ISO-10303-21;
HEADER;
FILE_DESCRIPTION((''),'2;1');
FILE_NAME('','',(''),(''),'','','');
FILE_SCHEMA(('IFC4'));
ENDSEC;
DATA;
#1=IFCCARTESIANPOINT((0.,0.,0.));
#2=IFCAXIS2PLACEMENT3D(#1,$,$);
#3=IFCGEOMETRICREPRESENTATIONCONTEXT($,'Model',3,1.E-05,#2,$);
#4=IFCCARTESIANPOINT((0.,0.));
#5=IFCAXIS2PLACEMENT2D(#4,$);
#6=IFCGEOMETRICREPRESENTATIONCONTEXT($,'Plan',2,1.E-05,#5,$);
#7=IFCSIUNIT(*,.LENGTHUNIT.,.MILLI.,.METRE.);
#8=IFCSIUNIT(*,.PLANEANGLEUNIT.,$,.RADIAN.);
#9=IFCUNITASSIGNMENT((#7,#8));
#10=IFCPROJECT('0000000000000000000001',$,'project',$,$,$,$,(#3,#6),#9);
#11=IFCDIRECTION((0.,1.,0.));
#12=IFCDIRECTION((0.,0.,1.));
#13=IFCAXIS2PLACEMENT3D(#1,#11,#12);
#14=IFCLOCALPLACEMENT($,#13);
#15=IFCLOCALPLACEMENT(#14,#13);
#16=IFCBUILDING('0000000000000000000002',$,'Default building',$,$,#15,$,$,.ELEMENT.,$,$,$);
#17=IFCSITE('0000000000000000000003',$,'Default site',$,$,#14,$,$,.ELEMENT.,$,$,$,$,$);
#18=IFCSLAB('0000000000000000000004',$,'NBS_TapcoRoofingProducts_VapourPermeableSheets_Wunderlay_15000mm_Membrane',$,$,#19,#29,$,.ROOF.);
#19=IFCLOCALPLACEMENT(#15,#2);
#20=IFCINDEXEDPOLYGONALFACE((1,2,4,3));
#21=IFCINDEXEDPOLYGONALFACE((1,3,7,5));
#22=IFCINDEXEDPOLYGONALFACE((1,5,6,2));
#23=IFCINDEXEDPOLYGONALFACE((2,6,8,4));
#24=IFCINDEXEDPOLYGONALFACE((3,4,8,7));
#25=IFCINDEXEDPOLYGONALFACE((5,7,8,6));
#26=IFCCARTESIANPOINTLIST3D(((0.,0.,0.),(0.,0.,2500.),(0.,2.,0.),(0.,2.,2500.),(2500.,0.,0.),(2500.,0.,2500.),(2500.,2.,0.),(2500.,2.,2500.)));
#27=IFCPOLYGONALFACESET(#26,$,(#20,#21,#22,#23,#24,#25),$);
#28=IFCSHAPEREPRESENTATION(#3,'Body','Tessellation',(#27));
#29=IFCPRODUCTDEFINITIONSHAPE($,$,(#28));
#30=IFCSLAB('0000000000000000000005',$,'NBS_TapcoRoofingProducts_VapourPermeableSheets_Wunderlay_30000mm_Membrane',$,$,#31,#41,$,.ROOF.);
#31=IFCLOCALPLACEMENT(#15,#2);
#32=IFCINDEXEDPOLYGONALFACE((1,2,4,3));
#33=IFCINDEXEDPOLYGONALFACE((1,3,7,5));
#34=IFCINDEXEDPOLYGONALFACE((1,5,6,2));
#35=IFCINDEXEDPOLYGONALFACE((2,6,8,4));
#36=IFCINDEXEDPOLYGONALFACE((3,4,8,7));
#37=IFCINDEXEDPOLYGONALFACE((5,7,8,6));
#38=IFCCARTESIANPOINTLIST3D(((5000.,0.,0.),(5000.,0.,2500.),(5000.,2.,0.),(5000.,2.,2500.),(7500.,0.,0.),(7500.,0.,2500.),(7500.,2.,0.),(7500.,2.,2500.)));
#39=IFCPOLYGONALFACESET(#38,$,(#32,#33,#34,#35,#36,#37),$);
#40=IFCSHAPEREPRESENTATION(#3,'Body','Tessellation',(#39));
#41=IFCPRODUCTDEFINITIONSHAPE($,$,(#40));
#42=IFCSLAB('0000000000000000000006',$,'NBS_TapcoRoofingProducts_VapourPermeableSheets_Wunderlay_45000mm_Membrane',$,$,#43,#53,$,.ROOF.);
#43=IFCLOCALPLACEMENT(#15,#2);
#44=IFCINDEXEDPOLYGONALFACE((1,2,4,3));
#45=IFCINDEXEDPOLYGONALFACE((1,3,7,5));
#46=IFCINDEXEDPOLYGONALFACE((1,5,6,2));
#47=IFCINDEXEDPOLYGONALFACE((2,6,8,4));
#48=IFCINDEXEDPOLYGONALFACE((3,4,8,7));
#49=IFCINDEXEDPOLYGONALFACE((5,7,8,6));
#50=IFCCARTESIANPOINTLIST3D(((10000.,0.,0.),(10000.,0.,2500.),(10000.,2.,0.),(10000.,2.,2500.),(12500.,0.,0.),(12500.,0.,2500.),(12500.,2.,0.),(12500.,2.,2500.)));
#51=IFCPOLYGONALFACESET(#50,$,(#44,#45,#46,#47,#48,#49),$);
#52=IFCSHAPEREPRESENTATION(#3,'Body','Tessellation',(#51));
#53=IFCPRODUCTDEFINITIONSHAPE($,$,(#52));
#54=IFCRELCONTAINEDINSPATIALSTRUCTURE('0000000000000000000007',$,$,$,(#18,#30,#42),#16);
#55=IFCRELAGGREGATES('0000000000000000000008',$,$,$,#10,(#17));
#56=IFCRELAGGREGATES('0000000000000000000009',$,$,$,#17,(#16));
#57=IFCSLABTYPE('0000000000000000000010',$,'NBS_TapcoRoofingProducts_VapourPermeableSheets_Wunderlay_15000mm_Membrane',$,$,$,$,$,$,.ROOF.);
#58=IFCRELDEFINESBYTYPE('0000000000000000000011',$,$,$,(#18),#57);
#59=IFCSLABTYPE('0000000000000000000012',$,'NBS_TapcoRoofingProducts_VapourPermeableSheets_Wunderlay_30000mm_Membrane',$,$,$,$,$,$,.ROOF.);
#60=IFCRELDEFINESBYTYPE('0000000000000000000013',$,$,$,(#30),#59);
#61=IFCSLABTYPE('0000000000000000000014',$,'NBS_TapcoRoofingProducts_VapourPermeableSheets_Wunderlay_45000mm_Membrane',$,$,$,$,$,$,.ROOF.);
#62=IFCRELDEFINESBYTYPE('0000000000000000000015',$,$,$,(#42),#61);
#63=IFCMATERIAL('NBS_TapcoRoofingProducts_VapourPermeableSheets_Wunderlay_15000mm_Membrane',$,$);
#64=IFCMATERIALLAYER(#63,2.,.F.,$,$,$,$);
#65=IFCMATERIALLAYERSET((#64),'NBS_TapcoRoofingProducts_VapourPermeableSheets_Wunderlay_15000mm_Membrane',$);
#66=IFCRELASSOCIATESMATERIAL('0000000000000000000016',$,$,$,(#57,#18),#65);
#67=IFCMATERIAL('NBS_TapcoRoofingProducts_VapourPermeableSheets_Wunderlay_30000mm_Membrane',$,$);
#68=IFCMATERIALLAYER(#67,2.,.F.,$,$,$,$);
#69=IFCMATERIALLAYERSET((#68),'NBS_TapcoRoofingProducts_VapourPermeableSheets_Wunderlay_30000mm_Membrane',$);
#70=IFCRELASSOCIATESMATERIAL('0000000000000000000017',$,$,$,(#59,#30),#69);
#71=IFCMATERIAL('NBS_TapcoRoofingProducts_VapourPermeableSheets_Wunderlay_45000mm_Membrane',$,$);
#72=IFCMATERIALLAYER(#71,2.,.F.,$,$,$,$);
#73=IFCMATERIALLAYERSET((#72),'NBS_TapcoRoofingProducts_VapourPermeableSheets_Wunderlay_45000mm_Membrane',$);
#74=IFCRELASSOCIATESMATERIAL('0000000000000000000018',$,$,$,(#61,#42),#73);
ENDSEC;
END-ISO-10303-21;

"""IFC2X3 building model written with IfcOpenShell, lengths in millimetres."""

from ifc_helpers import new_model, si_unit, frame, frame_2d, origin, origin_with_axes, origin_2d, place, context, project, spatial, rectangle, extrude, material, layer, layer_set, layer_usage, type_object, element, save


model = new_model("IFC2X3")

# Units and contexts
model_context = context("Model", 3, precision=1e-05, world=origin())
plan_context = context("Plan", 2, precision=1e-05, world=origin_2d())
ifc_project = project(units=[si_unit("LENGTHUNIT", "METRE", prefix="MILLI"), si_unit("PLANEANGLEUNIT", "RADIAN")], contexts=[model_context, plan_context])

# Site, building
site_placement = place(None, frame((0.0, 0.0, 0.0), z_axis=(0.0, 1.0, 0.0), x_axis=(0.0, 0.0, 1.0)))
site = spatial("IfcSite", under=ifc_project, at=site_placement, Name="Default site", CompositionType="ELEMENT")
building_placement = place(site_placement, frame((0.0, 0.0, 0.0), z_axis=(0.0, 1.0, 0.0), x_axis=(0.0, 0.0, 1.0)))
building = spatial("IfcBuilding", under=site, at=building_placement, Name="Default building", CompositionType="ELEMENT")

# Slabs
ifc_material_1 = material(Name="NBS_TapcoRoofingProducts_VapourPermeableSheets_Wunderlay_15000mm_Membrane")
ifc_layer_1 = layer(ifc_material_1, 2.0, ventilated=False)
ifc_layer_set_1 = layer_set([ifc_layer_1], Name="NBS_TapcoRoofingProducts_VapourPermeableSheets_Wunderlay_15000mm_Membrane")
ifc_layer_usage_1 = layer_usage(ifc_layer_set_1, "AXIS3", "NEGATIVE", 0.0)
slab_type_1 = type_object("IfcSlabType", Name="NBS_TapcoRoofingProducts_VapourPermeableSheets_Wunderlay_15000mm_Membrane", PredefinedType="ROOF", material=ifc_layer_set_1)
slab_1_placement = place(None, origin())
element("IfcSlab", 1, at=slab_1_placement, inside=building, type_object=slab_type_1, material=ifc_layer_usage_1, Name="NBS_TapcoRoofingProducts_VapourPermeableSheets_Wunderlay_15000mm_Membrane", PredefinedType="ROOF", context=model_context, shape_type="SweptSolid", body=[
    extrude(rectangle(XDim=2500.0, YDim=2500.0, at=frame_2d((1250.0, 1250.0))), origin_with_axes(), (0.0, 0.0, 1.0), 2.0),
])
ifc_material_2 = material(Name="NBS_TapcoRoofingProducts_VapourPermeableSheets_Wunderlay_30000mm_Membrane")
ifc_layer_2 = layer(ifc_material_2, 2.0, ventilated=False)
ifc_layer_set_2 = layer_set([ifc_layer_2], Name="NBS_TapcoRoofingProducts_VapourPermeableSheets_Wunderlay_30000mm_Membrane")
ifc_layer_usage_2 = layer_usage(ifc_layer_set_2, "AXIS3", "NEGATIVE", 0.0)
slab_type_2 = type_object("IfcSlabType", Name="NBS_TapcoRoofingProducts_VapourPermeableSheets_Wunderlay_30000mm_Membrane", PredefinedType="ROOF", material=ifc_layer_set_2)
slab_2_placement = place(None, frame((0.0, 5000.0, 0.0)))
element("IfcSlab", 2, at=slab_2_placement, inside=building, type_object=slab_type_2, material=ifc_layer_usage_2, Name="NBS_TapcoRoofingProducts_VapourPermeableSheets_Wunderlay_30000mm_Membrane", PredefinedType="ROOF", context=model_context, shape_type="SweptSolid", body=[
    extrude(rectangle(XDim=2500.0, YDim=2500.0, at=frame_2d((1250.0, 1250.0))), origin_with_axes(), (0.0, 0.0, 1.0), 2.0),
])
ifc_material_3 = material(Name="NBS_TapcoRoofingProducts_VapourPermeableSheets_Wunderlay_45000mm_Membrane")
ifc_layer_3 = layer(ifc_material_3, 2.0, ventilated=False)
ifc_layer_set_3 = layer_set([ifc_layer_3], Name="NBS_TapcoRoofingProducts_VapourPermeableSheets_Wunderlay_45000mm_Membrane")
ifc_layer_usage_3 = layer_usage(ifc_layer_set_3, "AXIS3", "NEGATIVE", 0.0)
slab_type_3 = type_object("IfcSlabType", Name="NBS_TapcoRoofingProducts_VapourPermeableSheets_Wunderlay_45000mm_Membrane", PredefinedType="ROOF", material=ifc_layer_set_3)
slab_3_placement = place(None, frame((0.0, 10000.0, 0.0)))
element("IfcSlab", 3, at=slab_3_placement, inside=building, type_object=slab_type_3, material=ifc_layer_usage_3, Name="NBS_TapcoRoofingProducts_VapourPermeableSheets_Wunderlay_45000mm_Membrane", PredefinedType="ROOF", context=model_context, shape_type="SweptSolid", body=[
    extrude(rectangle(XDim=2500.0, YDim=2500.0, at=frame_2d((1250.0, 1250.0))), origin_with_axes(), (0.0, 0.0, 1.0), 2.0),
])

save(model, "model.ifc")
